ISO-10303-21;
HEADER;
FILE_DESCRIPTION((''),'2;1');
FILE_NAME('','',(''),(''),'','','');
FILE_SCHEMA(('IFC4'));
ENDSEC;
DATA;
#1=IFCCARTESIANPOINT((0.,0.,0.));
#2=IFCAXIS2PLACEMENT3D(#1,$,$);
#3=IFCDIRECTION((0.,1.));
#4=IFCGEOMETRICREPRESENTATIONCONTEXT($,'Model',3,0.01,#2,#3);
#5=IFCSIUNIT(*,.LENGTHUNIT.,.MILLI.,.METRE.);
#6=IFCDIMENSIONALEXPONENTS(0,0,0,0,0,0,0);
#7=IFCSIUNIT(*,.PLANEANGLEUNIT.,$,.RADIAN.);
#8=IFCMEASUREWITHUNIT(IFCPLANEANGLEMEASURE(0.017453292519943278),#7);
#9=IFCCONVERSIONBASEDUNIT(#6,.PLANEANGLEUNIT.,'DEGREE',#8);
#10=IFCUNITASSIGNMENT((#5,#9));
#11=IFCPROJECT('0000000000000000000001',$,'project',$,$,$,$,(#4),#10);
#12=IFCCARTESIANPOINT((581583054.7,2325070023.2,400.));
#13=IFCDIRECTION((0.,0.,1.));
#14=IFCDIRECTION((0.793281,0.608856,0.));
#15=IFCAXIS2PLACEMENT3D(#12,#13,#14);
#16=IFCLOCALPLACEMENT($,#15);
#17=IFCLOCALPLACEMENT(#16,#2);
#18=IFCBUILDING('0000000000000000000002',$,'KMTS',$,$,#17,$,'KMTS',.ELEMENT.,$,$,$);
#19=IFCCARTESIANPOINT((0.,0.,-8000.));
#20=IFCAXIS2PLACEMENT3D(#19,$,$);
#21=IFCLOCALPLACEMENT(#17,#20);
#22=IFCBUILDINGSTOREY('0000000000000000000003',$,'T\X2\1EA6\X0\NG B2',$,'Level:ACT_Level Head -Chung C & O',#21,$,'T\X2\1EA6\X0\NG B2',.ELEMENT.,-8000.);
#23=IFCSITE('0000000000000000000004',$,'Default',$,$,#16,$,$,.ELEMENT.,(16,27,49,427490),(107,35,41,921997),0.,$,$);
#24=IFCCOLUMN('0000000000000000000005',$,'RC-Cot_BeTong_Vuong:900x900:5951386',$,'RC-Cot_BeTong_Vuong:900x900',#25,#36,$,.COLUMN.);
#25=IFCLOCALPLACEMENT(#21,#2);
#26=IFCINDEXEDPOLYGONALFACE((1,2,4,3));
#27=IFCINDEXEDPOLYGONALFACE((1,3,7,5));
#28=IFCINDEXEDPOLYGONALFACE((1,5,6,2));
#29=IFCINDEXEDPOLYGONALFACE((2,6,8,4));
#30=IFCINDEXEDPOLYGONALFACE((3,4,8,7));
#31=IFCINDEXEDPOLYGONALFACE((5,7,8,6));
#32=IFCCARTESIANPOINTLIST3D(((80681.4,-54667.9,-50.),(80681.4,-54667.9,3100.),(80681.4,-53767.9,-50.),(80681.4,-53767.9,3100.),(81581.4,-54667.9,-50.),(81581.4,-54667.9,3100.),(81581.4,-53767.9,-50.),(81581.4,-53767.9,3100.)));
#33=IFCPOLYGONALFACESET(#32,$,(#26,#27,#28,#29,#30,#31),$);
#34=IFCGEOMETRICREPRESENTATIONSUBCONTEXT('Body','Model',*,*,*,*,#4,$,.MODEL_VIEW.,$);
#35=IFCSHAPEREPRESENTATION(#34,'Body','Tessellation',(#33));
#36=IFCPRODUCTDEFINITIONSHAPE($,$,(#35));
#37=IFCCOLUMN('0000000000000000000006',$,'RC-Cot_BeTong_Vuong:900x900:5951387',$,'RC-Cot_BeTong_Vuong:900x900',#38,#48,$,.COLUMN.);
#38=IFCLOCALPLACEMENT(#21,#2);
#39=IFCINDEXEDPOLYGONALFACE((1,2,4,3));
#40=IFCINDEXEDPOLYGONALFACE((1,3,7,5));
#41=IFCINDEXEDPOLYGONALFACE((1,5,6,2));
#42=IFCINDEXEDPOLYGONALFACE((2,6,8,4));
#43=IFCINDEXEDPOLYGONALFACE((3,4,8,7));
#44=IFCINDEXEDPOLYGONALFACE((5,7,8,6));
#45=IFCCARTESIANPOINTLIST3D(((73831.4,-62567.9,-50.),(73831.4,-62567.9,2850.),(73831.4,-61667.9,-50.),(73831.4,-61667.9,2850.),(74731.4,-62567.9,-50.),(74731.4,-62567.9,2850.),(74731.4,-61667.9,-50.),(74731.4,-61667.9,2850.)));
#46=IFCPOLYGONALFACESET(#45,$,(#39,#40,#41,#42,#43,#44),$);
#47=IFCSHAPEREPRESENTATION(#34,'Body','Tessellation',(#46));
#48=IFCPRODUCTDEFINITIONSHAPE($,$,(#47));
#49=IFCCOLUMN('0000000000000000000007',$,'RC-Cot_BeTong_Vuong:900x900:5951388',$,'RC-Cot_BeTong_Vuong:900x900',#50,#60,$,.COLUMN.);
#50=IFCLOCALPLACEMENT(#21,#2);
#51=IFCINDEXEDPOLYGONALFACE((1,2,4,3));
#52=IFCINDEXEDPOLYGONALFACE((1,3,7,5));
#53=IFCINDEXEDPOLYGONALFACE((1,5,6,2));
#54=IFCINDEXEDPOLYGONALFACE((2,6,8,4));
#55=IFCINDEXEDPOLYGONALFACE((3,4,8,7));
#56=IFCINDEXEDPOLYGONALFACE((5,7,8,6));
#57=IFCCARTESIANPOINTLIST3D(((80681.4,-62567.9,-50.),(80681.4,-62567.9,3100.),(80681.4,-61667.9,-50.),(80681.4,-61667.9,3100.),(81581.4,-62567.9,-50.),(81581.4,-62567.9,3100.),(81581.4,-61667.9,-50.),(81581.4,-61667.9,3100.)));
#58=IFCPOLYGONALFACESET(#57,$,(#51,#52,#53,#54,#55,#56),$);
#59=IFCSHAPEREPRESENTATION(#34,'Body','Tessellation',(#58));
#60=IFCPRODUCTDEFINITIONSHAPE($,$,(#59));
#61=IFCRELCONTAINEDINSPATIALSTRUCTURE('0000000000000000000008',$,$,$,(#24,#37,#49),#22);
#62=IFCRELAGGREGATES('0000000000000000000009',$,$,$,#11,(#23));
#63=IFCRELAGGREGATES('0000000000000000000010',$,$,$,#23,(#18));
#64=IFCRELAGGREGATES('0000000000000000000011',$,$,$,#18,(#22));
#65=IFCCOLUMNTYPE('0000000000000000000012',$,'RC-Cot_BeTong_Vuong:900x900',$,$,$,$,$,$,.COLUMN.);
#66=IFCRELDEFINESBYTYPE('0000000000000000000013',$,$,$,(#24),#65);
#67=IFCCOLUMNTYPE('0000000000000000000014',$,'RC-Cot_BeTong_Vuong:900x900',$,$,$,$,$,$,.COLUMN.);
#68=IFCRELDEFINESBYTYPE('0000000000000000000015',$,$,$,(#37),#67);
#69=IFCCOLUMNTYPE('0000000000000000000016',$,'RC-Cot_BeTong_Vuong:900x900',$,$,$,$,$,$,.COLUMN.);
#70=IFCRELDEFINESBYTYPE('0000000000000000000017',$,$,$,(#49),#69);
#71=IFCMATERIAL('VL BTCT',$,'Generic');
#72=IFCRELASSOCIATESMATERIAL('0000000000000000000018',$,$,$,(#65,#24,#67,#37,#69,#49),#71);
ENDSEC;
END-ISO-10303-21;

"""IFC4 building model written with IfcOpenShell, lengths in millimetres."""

from ifc_helpers import new_model, entity, si_unit, converted_unit, direction, frame, origin, place, context, subcontext, project, spatial, indexed_curve, outline, extrude, source, transform, mapped, material, type_object, type_shapes, element, save


model = new_model("IFC4")

# Units and contexts
model_context = context("Model", 3, precision=0.01, world=origin(), true_north=direction((0.0, 1.0)))
body_context = subcontext(model_context, "Body", "Model", "MODEL_VIEW")
ifc_project = project(units=[si_unit("LENGTHUNIT", "METRE", prefix="MILLI"), converted_unit("PLANEANGLEUNIT", "DEGREE", entity("IfcPlaneAngleMeasure", 0.017453292519943278), si_unit("PLANEANGLEUNIT", "RADIAN"), dimensions=[0, 0, 0, 0, 0, 0, 0])], contexts=[model_context])

# Site, building, storey
site_placement = place(None, frame((581583054.7, 2325070023.2, 400.0), z_axis=(0.0, 0.0, 1.0), x_axis=(0.793281, 0.608856, 0.0)))
site = spatial("IfcSite", under=ifc_project, at=site_placement, Name="Default", CompositionType="ELEMENT", RefLatitude=(16, 27, 49, 427490), RefLongitude=(107, 35, 41, 921997), RefElevation=0.0)
building_placement = place(site_placement, origin())
building = spatial("IfcBuilding", under=site, at=building_placement, Name="KMTS", LongName="KMTS", CompositionType="ELEMENT")
storey_placement = place(building_placement, frame((0.0, 0.0, -8000.0)))
storey = spatial("IfcBuildingStorey", under=building, at=storey_placement, Name="TẦNG B2", ObjectType="Level:ACT_Level Head -Chung C & O", LongName="TẦNG B2", CompositionType="ELEMENT", Elevation=-8000.0)

# Columns
ifc_material = material(Name="VL BTCT", Category="Generic")
column_type_1 = type_object("IfcColumnType", Name="RC-Cot_BeTong_Vuong:900x900", PredefinedType="COLUMN", material=ifc_material)
shared_shape_1 = source(origin(), body_context, "Body", "SweptSolid", [
    extrude(outline(indexed_curve([(-450.0, -450.0), (450.0, -450.0), (450.0, 450.0), (-450.0, 450.0), (-450.0, -450.0)], self_intersect=False)), frame((81131.4, -54217.9, -8050.0), z_axis=(0.0, 0.0, 1.0), x_axis=(-1.0, 0.0, 0.0)), (0.0, 0.0, 1.0), 3150.0),
])
type_shapes(column_type_1, [shared_shape_1])
column_1_placement = place(storey_placement, frame((0.0, 0.0, 8000.0)))
element("IfcColumn", 1, at=column_1_placement, inside=storey, type_object=column_type_1, material=ifc_material, Name="RC-Cot_BeTong_Vuong:900x900:5951386", ObjectType="RC-Cot_BeTong_Vuong:900x900", PredefinedType="COLUMN", context=body_context, shape_type="MappedRepresentation", body=[
    mapped(shared_shape_1, transform((0.0, 0.0, 0.0), scale=1.0)),
])
column_type_2 = type_object("IfcColumnType", Name="RC-Cot_BeTong_Vuong:900x900", PredefinedType="COLUMN", material=ifc_material)
shared_shape_2 = source(origin(), body_context, "Body", "SweptSolid", [
    extrude(outline(indexed_curve([(-450.0, -450.0), (450.0, -450.0), (450.0, 450.0), (-450.0, 450.0), (-450.0, -450.0)], self_intersect=False)), frame((74281.4, -62117.9, -8050.0), z_axis=(0.0, 0.0, 1.0), x_axis=(-1.0, 0.0, 0.0)), (0.0, 0.0, 1.0), 2900.0),
])
type_shapes(column_type_2, [shared_shape_2])
column_2_placement = place(storey_placement, frame((0.0, 0.0, 8000.0)))
element("IfcColumn", 2, at=column_2_placement, inside=storey, type_object=column_type_2, material=ifc_material, Name="RC-Cot_BeTong_Vuong:900x900:5951387", ObjectType="RC-Cot_BeTong_Vuong:900x900", PredefinedType="COLUMN", context=body_context, shape_type="MappedRepresentation", body=[
    mapped(shared_shape_2, transform((0.0, 0.0, 0.0), scale=1.0)),
])
column_type_3 = type_object("IfcColumnType", Name="RC-Cot_BeTong_Vuong:900x900", PredefinedType="COLUMN", material=ifc_material)
shared_shape_3 = source(origin(), body_context, "Body", "SweptSolid", [
    extrude(outline(indexed_curve([(-450.0, -450.0), (450.0, -450.0), (450.0, 450.0), (-450.0, 450.0), (-450.0, -450.0)], self_intersect=False)), frame((81131.4, -62117.9, -8050.0), z_axis=(0.0, 0.0, 1.0), x_axis=(-1.0, 0.0, 0.0)), (0.0, 0.0, 1.0), 3150.0),
])
type_shapes(column_type_3, [shared_shape_3])
column_3_placement = place(storey_placement, frame((0.0, 0.0, 8000.0)))
element("IfcColumn", 3, at=column_3_placement, inside=storey, type_object=column_type_3, material=ifc_material, Name="RC-Cot_BeTong_Vuong:900x900:5951388", ObjectType="RC-Cot_BeTong_Vuong:900x900", PredefinedType="COLUMN", context=body_context, shape_type="MappedRepresentation", body=[
    mapped(shared_shape_3, transform((0.0, 0.0, 0.0), scale=1.0)),
])

save(model, "model.ifc")
